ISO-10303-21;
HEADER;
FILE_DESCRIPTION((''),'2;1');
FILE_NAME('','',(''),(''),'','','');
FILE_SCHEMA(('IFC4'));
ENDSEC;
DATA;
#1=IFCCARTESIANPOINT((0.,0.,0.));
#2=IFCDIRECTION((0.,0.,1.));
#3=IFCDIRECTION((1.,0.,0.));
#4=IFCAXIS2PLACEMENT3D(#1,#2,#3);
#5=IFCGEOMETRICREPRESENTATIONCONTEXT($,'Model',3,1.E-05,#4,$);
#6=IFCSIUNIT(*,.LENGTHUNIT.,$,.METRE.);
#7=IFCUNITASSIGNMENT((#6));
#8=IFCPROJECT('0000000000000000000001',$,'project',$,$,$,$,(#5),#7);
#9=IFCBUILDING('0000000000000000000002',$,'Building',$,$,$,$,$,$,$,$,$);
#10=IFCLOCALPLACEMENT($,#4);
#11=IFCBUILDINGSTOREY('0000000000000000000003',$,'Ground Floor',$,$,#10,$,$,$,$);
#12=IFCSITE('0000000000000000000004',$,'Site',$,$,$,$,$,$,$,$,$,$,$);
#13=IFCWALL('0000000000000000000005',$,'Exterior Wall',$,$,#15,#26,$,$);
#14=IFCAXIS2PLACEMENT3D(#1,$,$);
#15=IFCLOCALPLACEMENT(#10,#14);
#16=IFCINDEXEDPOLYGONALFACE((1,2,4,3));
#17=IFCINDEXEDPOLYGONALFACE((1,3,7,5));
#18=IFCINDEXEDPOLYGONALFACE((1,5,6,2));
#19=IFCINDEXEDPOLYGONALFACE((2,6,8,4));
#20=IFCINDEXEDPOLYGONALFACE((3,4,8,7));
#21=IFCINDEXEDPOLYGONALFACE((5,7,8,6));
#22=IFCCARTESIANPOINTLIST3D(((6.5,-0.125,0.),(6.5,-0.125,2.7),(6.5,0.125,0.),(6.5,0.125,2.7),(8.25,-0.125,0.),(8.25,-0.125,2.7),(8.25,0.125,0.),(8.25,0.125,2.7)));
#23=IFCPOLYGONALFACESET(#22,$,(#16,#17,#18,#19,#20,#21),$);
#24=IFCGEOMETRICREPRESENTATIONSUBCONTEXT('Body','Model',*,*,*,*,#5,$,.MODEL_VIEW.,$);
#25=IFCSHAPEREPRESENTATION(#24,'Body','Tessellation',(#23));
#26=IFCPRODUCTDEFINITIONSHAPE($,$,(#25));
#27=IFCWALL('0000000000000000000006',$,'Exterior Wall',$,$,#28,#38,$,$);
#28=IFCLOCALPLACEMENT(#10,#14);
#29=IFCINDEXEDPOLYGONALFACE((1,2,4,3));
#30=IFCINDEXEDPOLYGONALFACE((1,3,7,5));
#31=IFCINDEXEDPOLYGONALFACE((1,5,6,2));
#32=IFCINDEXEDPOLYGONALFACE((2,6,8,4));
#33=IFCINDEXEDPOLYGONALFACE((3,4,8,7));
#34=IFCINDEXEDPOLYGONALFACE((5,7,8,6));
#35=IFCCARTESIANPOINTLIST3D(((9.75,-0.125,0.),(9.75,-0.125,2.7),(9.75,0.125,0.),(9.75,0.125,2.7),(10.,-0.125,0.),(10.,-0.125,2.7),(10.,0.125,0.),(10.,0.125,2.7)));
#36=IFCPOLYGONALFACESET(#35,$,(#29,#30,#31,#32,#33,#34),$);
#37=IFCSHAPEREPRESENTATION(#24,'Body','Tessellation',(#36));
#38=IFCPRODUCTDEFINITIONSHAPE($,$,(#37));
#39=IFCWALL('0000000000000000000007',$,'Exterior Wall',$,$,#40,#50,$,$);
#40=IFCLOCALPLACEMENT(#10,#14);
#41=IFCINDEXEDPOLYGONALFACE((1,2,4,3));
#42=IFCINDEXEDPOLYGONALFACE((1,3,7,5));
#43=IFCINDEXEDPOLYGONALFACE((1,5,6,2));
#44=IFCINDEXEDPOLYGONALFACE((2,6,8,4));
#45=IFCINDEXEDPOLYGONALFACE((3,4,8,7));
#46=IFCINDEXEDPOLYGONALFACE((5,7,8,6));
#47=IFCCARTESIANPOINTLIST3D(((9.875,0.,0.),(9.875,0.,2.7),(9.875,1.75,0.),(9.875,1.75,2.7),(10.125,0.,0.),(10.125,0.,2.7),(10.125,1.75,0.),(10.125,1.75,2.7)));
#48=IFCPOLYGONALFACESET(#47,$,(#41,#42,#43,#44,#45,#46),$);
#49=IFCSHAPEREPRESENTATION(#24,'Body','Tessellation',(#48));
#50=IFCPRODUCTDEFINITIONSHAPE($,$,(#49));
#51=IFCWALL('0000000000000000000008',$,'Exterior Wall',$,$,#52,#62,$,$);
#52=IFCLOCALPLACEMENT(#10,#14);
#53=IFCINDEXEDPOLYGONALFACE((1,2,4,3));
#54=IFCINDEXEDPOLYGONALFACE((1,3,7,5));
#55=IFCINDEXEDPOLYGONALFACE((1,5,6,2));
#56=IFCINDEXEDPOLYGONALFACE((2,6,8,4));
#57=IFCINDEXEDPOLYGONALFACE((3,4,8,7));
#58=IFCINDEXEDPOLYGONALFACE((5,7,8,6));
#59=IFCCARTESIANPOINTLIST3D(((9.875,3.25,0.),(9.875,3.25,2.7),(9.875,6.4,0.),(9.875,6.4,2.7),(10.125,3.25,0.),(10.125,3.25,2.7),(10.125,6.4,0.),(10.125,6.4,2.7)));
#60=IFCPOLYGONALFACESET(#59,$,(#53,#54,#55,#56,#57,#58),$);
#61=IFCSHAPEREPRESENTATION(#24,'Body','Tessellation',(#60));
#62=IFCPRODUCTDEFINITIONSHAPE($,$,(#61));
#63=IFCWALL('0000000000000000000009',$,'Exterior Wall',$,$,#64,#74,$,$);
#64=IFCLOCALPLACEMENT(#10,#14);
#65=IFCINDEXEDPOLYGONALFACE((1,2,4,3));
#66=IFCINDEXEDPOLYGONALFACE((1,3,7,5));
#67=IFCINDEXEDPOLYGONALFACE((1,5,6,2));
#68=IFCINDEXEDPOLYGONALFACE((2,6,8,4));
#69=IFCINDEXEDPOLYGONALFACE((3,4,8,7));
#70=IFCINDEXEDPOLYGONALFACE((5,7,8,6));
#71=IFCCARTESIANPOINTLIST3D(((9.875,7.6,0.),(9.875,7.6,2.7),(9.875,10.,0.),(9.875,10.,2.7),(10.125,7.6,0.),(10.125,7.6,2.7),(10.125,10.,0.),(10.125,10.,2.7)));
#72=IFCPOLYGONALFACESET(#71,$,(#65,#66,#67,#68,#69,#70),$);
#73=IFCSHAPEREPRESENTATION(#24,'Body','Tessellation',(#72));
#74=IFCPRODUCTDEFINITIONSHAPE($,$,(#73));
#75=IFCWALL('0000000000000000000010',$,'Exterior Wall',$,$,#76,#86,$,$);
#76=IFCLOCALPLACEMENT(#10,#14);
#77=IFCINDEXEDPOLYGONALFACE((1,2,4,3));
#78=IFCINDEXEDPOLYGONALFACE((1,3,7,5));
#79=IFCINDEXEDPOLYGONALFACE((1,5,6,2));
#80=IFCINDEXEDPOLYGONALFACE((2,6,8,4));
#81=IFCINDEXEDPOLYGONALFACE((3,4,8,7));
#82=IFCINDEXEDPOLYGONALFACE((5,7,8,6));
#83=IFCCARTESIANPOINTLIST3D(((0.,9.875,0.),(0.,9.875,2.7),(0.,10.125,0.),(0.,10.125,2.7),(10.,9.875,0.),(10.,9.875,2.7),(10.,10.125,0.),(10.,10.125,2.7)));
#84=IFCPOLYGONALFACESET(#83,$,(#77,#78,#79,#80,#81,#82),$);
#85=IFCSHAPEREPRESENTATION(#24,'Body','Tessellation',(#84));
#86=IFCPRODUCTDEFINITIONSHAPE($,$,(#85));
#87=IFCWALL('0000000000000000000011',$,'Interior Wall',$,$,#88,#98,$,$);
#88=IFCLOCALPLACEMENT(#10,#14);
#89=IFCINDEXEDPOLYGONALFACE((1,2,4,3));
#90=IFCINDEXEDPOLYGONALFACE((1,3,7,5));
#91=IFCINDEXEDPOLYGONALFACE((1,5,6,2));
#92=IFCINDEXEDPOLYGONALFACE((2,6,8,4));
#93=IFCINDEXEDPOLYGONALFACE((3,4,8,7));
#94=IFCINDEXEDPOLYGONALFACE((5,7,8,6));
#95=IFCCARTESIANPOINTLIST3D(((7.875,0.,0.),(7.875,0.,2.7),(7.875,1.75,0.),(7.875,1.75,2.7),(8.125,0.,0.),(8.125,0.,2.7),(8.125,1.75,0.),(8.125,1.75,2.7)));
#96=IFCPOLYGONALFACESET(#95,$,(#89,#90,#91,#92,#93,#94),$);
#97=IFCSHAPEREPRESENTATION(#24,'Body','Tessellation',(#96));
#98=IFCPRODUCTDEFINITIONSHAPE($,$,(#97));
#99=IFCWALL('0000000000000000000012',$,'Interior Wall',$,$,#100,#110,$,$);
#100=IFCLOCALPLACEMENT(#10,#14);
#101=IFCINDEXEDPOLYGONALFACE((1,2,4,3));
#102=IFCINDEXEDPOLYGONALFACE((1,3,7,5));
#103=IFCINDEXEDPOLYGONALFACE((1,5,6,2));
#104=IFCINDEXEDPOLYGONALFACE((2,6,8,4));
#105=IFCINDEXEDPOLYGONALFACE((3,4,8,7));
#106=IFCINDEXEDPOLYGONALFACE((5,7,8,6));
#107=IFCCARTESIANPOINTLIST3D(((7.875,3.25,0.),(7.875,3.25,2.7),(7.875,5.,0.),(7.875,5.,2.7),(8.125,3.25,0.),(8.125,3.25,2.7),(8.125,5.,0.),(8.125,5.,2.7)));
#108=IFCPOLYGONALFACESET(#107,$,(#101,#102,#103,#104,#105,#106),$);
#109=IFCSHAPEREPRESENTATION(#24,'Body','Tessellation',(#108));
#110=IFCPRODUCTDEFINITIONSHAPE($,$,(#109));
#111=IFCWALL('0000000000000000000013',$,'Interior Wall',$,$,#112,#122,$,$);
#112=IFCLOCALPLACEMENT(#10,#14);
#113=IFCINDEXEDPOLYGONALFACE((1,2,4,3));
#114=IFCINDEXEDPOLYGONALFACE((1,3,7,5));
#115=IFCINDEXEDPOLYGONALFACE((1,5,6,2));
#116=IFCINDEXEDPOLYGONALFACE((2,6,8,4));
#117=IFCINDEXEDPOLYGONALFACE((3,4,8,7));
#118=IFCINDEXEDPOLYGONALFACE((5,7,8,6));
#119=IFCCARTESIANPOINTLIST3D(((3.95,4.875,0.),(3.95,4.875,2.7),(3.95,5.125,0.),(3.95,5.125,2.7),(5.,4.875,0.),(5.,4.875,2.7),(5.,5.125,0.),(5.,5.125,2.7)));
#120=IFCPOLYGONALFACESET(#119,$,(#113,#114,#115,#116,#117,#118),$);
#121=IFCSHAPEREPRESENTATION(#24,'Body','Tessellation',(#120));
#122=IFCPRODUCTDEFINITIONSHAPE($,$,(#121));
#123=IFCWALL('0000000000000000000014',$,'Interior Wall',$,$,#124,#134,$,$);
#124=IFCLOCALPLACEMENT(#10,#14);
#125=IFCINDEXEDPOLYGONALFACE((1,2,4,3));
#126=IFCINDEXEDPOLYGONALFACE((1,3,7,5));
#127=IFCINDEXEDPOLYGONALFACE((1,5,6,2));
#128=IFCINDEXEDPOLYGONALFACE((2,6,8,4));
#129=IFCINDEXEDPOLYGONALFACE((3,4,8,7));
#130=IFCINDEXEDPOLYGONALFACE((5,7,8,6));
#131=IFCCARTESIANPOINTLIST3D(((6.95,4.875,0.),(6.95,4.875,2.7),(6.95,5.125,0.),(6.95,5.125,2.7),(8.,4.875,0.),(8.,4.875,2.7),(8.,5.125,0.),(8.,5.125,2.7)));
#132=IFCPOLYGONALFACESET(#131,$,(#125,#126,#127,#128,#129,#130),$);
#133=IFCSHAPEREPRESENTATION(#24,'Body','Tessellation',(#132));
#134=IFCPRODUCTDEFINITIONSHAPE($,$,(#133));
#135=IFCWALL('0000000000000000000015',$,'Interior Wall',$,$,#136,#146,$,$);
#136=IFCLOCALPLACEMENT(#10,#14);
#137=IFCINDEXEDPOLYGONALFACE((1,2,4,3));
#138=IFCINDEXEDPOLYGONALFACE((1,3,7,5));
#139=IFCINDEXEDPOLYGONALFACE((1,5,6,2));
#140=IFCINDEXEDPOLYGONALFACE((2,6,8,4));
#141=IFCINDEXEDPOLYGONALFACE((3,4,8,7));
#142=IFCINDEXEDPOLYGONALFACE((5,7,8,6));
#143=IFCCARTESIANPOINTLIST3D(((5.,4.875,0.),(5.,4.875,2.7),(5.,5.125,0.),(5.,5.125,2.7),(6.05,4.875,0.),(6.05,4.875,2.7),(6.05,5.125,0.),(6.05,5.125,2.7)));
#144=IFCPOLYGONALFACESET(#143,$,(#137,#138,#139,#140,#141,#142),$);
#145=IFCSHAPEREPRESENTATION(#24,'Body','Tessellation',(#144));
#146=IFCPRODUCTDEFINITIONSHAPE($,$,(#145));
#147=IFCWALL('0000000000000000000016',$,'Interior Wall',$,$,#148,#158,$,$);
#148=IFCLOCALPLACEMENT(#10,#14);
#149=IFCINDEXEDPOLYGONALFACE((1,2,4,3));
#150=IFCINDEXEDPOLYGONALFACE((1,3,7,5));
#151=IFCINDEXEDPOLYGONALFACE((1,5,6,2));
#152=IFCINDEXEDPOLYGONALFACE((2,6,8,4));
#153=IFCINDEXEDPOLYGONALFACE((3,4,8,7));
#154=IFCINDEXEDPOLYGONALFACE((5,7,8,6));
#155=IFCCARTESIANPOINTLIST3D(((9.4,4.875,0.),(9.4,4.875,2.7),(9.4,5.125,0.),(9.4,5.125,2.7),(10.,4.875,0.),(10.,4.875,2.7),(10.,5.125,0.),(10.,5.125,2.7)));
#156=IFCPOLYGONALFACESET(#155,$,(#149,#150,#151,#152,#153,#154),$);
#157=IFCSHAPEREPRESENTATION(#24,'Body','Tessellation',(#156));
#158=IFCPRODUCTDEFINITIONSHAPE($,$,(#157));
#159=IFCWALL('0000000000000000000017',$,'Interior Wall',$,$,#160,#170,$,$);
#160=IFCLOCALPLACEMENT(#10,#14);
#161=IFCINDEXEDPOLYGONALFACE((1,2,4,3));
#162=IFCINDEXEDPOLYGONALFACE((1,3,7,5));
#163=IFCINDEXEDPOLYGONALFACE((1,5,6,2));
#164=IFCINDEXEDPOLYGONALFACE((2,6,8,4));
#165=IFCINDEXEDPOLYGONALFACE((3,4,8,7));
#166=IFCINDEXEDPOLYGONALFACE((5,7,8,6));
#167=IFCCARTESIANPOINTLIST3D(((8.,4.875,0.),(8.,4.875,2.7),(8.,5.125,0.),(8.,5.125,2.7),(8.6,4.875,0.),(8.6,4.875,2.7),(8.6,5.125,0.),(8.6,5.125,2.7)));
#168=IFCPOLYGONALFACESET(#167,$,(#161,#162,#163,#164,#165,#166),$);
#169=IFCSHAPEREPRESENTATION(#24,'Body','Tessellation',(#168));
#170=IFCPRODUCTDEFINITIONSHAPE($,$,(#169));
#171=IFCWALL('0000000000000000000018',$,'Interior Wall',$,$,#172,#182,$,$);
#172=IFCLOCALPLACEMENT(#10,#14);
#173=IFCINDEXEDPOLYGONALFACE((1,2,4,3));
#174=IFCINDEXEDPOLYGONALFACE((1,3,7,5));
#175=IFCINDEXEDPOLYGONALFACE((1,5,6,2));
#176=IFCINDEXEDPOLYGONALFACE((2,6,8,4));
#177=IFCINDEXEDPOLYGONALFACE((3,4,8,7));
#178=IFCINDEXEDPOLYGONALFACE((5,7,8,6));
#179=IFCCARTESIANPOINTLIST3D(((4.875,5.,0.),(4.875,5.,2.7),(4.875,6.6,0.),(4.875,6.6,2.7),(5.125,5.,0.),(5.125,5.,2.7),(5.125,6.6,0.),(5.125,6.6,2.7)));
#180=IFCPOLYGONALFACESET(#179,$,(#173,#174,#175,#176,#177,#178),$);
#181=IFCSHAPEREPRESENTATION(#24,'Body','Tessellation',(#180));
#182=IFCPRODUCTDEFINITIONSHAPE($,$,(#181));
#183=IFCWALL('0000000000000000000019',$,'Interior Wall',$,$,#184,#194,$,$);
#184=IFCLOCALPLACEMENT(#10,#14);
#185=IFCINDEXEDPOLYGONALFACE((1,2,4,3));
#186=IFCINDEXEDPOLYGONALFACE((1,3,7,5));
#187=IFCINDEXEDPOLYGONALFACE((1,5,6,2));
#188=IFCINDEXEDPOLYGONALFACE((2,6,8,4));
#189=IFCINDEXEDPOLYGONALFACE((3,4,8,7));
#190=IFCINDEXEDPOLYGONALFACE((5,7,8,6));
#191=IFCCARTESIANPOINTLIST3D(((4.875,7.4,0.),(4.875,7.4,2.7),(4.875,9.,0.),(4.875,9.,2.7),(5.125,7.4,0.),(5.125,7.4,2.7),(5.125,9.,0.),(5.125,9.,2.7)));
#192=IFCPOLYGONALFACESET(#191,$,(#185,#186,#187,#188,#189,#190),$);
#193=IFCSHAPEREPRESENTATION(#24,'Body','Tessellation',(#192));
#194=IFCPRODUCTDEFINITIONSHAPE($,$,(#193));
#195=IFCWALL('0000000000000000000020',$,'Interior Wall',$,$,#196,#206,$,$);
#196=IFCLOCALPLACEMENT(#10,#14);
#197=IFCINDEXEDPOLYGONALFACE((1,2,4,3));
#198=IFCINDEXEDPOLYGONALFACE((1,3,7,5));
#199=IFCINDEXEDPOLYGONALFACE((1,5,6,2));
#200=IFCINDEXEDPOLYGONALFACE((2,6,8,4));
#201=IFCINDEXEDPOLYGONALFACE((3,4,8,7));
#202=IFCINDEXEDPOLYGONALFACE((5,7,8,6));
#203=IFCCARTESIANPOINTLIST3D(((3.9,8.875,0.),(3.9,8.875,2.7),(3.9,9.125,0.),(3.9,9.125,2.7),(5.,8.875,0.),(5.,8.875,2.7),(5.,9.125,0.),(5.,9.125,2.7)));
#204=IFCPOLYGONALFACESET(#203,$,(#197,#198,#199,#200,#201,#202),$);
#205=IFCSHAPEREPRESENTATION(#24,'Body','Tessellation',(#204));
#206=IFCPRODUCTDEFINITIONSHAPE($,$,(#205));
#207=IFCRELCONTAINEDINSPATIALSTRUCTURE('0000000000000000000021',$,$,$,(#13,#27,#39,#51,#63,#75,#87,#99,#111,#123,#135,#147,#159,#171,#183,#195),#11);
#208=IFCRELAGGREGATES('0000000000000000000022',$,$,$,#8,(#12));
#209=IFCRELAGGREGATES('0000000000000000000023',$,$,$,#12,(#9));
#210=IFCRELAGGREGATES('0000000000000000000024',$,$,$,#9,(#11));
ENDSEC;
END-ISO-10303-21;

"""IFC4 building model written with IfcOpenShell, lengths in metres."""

from ifc_helpers import new_model, si_unit, frame, origin_with_axes, place, context, subcontext, project, spatial, indexed_curve, outline, extrude, element, save


model = new_model("IFC4")

# Units and contexts
model_context = context("Model", 3, precision=1e-05, world=origin_with_axes())
body_context = subcontext(model_context, "Body", "Model", "MODEL_VIEW")
ifc_project = project(units=[si_unit("LENGTHUNIT", "METRE")], contexts=[model_context])

# Site, building, storey
site = spatial("IfcSite", under=ifc_project, Name="Site")
building = spatial("IfcBuilding", under=site, Name="Building")
storey_placement = place(None, origin_with_axes())
storey = spatial("IfcBuildingStorey", under=building, at=storey_placement, Name="Ground Floor")

# Walls
wall_1_placement = place(storey_placement, frame((6.5, 0.0, 0.0), z_axis=(0.0, 0.0, 1.0), x_axis=(1.0, 0.0, 0.0)))
element("IfcWall", 1, at=wall_1_placement, inside=storey, Name="Exterior Wall", context=body_context, shape_type="SweptSolid", body=[
    extrude(outline(indexed_curve([(0.0, 0.0), (0.0, 0.25), (1.75, 0.25), (1.75, 0.0), (0.0, 0.0)], self_intersect=False)), frame((0.0, -0.125, 0.0), z_axis=(0.0, 0.0, 1.0), x_axis=(1.0, 0.0, 0.0)), (0.0, 0.0, 1.0), 2.7),
])
wall_2_placement = place(storey_placement, frame((9.75, 0.0, 0.0), z_axis=(0.0, 0.0, 1.0), x_axis=(1.0, 0.0, 0.0)))
element("IfcWall", 2, at=wall_2_placement, inside=storey, Name="Exterior Wall", context=body_context, shape_type="SweptSolid", body=[
    extrude(outline(indexed_curve([(0.0, 0.0), (0.0, 0.25), (0.25, 0.25), (0.25, 0.0), (0.0, 0.0)], self_intersect=False)), frame((0.0, -0.125, 0.0), z_axis=(0.0, 0.0, 1.0), x_axis=(1.0, 0.0, 0.0)), (0.0, 0.0, 1.0), 2.7),
])
wall_3_placement = place(storey_placement, frame((10.0, 0.0, 0.0), z_axis=(0.0, 0.0, 1.0), x_axis=(0.0, 1.0, 0.0)))
element("IfcWall", 3, at=wall_3_placement, inside=storey, Name="Exterior Wall", context=body_context, shape_type="SweptSolid", body=[
    extrude(outline(indexed_curve([(0.0, 0.0), (0.0, 0.25), (1.75, 0.25), (1.75, 0.0), (0.0, 0.0)], self_intersect=False)), frame((0.0, -0.125, 0.0), z_axis=(0.0, 0.0, 1.0), x_axis=(1.0, 0.0, 0.0)), (0.0, 0.0, 1.0), 2.7),
])
wall_4_placement = place(storey_placement, frame((10.0, 3.25, 0.0), z_axis=(0.0, 0.0, 1.0), x_axis=(0.0, 1.0, 0.0)))
element("IfcWall", 4, at=wall_4_placement, inside=storey, Name="Exterior Wall", context=body_context, shape_type="SweptSolid", body=[
    extrude(outline(indexed_curve([(0.0, 0.0), (0.0, 0.25), (3.15, 0.25), (3.15, 0.0), (0.0, 0.0)], self_intersect=False)), frame((0.0, -0.125, 0.0), z_axis=(0.0, 0.0, 1.0), x_axis=(1.0, 0.0, 0.0)), (0.0, 0.0, 1.0), 2.7),
])
wall_5_placement = place(storey_placement, frame((10.0, 7.6, 0.0), z_axis=(0.0, 0.0, 1.0), x_axis=(0.0, 1.0, 0.0)))
element("IfcWall", 5, at=wall_5_placement, inside=storey, Name="Exterior Wall", context=body_context, shape_type="SweptSolid", body=[
    extrude(outline(indexed_curve([(0.0, 0.0), (0.0, 0.25), (2.4, 0.25), (2.4, 0.0), (0.0, 0.0)], self_intersect=False)), frame((0.0, -0.125, 0.0), z_axis=(0.0, 0.0, 1.0), x_axis=(1.0, 0.0, 0.0)), (0.0, 0.0, 1.0), 2.7),
])
wall_6_placement = place(storey_placement, frame((10.0, 10.0, 0.0), z_axis=(0.0, 0.0, 1.0), x_axis=(-1.0, 0.0, 0.0)))
element("IfcWall", 6, at=wall_6_placement, inside=storey, Name="Exterior Wall", context=body_context, shape_type="SweptSolid", body=[
    extrude(outline(indexed_curve([(0.0, 0.0), (0.0, 0.25), (10.0, 0.25), (10.0, 0.0), (0.0, 0.0)], self_intersect=False)), frame((0.0, -0.125, 0.0), z_axis=(0.0, 0.0, 1.0), x_axis=(1.0, 0.0, 0.0)), (0.0, 0.0, 1.0), 2.7),
])
for number, where, z_axis, x_axis, name in (
    (7, (8.0, 0.0, 0.0), (0.0, 0.0, 1.0), (0.0, 1.0, 0.0), "Interior Wall"),
    (8, (8.0, 3.25, 0.0), (0.0, 0.0, 1.0), (0.0, 1.0, 0.0), "Interior Wall"),
):
    element("IfcWall", number, at=place(storey_placement, frame(where, z_axis=z_axis, x_axis=x_axis)), inside=storey, Name=name, context=body_context, shape_type="SweptSolid", body=[
        extrude(outline(indexed_curve([(0.0, 0.0), (0.0, 0.25), (1.75, 0.25), (1.75, 0.0), (0.0, 0.0)], self_intersect=False)), frame((0.0, -0.125, 0.0), z_axis=(0.0, 0.0, 1.0), x_axis=(1.0, 0.0, 0.0)), (0.0, 0.0, 1.0), 2.7),
    ])
for number, where, z_axis, x_axis, name in (
    (9, (5.0, 5.0, 0.0), (0.0, 0.0, 1.0), (-1.0, 0.0, 0.0), "Interior Wall"),
    (10, (8.0, 5.0, 0.0), (0.0, 0.0, 1.0), (-1.0, 0.0, 0.0), "Interior Wall"),
    (11, (6.05, 5.0, 0.0), (0.0, 0.0, 1.0), (-1.0, 0.0, 0.0), "Interior Wall"),
):
    element("IfcWall", number, at=place(storey_placement, frame(where, z_axis=z_axis, x_axis=x_axis)), inside=storey, Name=name, context=body_context, shape_type="SweptSolid", body=[
        extrude(outline(indexed_curve([(0.0, 0.0), (0.0, 0.25), (1.05, 0.25), (1.05, 0.0), (0.0, 0.0)], self_intersect=False)), frame((0.0, -0.125, 0.0), z_axis=(0.0, 0.0, 1.0), x_axis=(1.0, 0.0, 0.0)), (0.0, 0.0, 1.0), 2.7),
    ])
for number, where, z_axis, x_axis, name in (
    (12, (10.0, 5.0, 0.0), (0.0, 0.0, 1.0), (-1.0, 0.0, 0.0), "Interior Wall"),
    (13, (8.6, 5.0, 0.0), (0.0, 0.0, 1.0), (-1.0, 0.0, 0.0), "Interior Wall"),
):
    element("IfcWall", number, at=place(storey_placement, frame(where, z_axis=z_axis, x_axis=x_axis)), inside=storey, Name=name, context=body_context, shape_type="SweptSolid", body=[
        extrude(outline(indexed_curve([(0.0, 0.0), (0.0, 0.25), (0.6, 0.25), (0.6, 0.0), (0.0, 0.0)], self_intersect=False)), frame((0.0, -0.125, 0.0), z_axis=(0.0, 0.0, 1.0), x_axis=(1.0, 0.0, 0.0)), (0.0, 0.0, 1.0), 2.7),
    ])
for number, where, z_axis, x_axis, name in (
    (14, (5.0, 5.0, 0.0), (0.0, 0.0, 1.0), (0.0, 1.0, 0.0), "Interior Wall"),
    (15, (5.0, 7.4, 0.0), (0.0, 0.0, 1.0), (0.0, 1.0, 0.0), "Interior Wall"),
):
    element("IfcWall", number, at=place(storey_placement, frame(where, z_axis=z_axis, x_axis=x_axis)), inside=storey, Name=name, context=body_context, shape_type="SweptSolid", body=[
        extrude(outline(indexed_curve([(0.0, 0.0), (0.0, 0.25), (1.6, 0.25), (1.6, 0.0), (0.0, 0.0)], self_intersect=False)), frame((0.0, -0.125, 0.0), z_axis=(0.0, 0.0, 1.0), x_axis=(1.0, 0.0, 0.0)), (0.0, 0.0, 1.0), 2.7),
    ])
wall_7_placement = place(storey_placement, frame((5.0, 9.0, 0.0), z_axis=(0.0, 0.0, 1.0), x_axis=(-1.0, 0.0, 0.0)))
element("IfcWall", 16, at=wall_7_placement, inside=storey, Name="Interior Wall", context=body_context, shape_type="SweptSolid", body=[
    extrude(outline(indexed_curve([(0.0, 0.0), (0.0, 0.25), (1.1, 0.25), (1.1, 0.0), (0.0, 0.0)], self_intersect=False)), frame((0.0, -0.125, 0.0), z_axis=(0.0, 0.0, 1.0), x_axis=(1.0, 0.0, 0.0)), (0.0, 0.0, 1.0), 2.7),
])

save(model, "model.ifc")
